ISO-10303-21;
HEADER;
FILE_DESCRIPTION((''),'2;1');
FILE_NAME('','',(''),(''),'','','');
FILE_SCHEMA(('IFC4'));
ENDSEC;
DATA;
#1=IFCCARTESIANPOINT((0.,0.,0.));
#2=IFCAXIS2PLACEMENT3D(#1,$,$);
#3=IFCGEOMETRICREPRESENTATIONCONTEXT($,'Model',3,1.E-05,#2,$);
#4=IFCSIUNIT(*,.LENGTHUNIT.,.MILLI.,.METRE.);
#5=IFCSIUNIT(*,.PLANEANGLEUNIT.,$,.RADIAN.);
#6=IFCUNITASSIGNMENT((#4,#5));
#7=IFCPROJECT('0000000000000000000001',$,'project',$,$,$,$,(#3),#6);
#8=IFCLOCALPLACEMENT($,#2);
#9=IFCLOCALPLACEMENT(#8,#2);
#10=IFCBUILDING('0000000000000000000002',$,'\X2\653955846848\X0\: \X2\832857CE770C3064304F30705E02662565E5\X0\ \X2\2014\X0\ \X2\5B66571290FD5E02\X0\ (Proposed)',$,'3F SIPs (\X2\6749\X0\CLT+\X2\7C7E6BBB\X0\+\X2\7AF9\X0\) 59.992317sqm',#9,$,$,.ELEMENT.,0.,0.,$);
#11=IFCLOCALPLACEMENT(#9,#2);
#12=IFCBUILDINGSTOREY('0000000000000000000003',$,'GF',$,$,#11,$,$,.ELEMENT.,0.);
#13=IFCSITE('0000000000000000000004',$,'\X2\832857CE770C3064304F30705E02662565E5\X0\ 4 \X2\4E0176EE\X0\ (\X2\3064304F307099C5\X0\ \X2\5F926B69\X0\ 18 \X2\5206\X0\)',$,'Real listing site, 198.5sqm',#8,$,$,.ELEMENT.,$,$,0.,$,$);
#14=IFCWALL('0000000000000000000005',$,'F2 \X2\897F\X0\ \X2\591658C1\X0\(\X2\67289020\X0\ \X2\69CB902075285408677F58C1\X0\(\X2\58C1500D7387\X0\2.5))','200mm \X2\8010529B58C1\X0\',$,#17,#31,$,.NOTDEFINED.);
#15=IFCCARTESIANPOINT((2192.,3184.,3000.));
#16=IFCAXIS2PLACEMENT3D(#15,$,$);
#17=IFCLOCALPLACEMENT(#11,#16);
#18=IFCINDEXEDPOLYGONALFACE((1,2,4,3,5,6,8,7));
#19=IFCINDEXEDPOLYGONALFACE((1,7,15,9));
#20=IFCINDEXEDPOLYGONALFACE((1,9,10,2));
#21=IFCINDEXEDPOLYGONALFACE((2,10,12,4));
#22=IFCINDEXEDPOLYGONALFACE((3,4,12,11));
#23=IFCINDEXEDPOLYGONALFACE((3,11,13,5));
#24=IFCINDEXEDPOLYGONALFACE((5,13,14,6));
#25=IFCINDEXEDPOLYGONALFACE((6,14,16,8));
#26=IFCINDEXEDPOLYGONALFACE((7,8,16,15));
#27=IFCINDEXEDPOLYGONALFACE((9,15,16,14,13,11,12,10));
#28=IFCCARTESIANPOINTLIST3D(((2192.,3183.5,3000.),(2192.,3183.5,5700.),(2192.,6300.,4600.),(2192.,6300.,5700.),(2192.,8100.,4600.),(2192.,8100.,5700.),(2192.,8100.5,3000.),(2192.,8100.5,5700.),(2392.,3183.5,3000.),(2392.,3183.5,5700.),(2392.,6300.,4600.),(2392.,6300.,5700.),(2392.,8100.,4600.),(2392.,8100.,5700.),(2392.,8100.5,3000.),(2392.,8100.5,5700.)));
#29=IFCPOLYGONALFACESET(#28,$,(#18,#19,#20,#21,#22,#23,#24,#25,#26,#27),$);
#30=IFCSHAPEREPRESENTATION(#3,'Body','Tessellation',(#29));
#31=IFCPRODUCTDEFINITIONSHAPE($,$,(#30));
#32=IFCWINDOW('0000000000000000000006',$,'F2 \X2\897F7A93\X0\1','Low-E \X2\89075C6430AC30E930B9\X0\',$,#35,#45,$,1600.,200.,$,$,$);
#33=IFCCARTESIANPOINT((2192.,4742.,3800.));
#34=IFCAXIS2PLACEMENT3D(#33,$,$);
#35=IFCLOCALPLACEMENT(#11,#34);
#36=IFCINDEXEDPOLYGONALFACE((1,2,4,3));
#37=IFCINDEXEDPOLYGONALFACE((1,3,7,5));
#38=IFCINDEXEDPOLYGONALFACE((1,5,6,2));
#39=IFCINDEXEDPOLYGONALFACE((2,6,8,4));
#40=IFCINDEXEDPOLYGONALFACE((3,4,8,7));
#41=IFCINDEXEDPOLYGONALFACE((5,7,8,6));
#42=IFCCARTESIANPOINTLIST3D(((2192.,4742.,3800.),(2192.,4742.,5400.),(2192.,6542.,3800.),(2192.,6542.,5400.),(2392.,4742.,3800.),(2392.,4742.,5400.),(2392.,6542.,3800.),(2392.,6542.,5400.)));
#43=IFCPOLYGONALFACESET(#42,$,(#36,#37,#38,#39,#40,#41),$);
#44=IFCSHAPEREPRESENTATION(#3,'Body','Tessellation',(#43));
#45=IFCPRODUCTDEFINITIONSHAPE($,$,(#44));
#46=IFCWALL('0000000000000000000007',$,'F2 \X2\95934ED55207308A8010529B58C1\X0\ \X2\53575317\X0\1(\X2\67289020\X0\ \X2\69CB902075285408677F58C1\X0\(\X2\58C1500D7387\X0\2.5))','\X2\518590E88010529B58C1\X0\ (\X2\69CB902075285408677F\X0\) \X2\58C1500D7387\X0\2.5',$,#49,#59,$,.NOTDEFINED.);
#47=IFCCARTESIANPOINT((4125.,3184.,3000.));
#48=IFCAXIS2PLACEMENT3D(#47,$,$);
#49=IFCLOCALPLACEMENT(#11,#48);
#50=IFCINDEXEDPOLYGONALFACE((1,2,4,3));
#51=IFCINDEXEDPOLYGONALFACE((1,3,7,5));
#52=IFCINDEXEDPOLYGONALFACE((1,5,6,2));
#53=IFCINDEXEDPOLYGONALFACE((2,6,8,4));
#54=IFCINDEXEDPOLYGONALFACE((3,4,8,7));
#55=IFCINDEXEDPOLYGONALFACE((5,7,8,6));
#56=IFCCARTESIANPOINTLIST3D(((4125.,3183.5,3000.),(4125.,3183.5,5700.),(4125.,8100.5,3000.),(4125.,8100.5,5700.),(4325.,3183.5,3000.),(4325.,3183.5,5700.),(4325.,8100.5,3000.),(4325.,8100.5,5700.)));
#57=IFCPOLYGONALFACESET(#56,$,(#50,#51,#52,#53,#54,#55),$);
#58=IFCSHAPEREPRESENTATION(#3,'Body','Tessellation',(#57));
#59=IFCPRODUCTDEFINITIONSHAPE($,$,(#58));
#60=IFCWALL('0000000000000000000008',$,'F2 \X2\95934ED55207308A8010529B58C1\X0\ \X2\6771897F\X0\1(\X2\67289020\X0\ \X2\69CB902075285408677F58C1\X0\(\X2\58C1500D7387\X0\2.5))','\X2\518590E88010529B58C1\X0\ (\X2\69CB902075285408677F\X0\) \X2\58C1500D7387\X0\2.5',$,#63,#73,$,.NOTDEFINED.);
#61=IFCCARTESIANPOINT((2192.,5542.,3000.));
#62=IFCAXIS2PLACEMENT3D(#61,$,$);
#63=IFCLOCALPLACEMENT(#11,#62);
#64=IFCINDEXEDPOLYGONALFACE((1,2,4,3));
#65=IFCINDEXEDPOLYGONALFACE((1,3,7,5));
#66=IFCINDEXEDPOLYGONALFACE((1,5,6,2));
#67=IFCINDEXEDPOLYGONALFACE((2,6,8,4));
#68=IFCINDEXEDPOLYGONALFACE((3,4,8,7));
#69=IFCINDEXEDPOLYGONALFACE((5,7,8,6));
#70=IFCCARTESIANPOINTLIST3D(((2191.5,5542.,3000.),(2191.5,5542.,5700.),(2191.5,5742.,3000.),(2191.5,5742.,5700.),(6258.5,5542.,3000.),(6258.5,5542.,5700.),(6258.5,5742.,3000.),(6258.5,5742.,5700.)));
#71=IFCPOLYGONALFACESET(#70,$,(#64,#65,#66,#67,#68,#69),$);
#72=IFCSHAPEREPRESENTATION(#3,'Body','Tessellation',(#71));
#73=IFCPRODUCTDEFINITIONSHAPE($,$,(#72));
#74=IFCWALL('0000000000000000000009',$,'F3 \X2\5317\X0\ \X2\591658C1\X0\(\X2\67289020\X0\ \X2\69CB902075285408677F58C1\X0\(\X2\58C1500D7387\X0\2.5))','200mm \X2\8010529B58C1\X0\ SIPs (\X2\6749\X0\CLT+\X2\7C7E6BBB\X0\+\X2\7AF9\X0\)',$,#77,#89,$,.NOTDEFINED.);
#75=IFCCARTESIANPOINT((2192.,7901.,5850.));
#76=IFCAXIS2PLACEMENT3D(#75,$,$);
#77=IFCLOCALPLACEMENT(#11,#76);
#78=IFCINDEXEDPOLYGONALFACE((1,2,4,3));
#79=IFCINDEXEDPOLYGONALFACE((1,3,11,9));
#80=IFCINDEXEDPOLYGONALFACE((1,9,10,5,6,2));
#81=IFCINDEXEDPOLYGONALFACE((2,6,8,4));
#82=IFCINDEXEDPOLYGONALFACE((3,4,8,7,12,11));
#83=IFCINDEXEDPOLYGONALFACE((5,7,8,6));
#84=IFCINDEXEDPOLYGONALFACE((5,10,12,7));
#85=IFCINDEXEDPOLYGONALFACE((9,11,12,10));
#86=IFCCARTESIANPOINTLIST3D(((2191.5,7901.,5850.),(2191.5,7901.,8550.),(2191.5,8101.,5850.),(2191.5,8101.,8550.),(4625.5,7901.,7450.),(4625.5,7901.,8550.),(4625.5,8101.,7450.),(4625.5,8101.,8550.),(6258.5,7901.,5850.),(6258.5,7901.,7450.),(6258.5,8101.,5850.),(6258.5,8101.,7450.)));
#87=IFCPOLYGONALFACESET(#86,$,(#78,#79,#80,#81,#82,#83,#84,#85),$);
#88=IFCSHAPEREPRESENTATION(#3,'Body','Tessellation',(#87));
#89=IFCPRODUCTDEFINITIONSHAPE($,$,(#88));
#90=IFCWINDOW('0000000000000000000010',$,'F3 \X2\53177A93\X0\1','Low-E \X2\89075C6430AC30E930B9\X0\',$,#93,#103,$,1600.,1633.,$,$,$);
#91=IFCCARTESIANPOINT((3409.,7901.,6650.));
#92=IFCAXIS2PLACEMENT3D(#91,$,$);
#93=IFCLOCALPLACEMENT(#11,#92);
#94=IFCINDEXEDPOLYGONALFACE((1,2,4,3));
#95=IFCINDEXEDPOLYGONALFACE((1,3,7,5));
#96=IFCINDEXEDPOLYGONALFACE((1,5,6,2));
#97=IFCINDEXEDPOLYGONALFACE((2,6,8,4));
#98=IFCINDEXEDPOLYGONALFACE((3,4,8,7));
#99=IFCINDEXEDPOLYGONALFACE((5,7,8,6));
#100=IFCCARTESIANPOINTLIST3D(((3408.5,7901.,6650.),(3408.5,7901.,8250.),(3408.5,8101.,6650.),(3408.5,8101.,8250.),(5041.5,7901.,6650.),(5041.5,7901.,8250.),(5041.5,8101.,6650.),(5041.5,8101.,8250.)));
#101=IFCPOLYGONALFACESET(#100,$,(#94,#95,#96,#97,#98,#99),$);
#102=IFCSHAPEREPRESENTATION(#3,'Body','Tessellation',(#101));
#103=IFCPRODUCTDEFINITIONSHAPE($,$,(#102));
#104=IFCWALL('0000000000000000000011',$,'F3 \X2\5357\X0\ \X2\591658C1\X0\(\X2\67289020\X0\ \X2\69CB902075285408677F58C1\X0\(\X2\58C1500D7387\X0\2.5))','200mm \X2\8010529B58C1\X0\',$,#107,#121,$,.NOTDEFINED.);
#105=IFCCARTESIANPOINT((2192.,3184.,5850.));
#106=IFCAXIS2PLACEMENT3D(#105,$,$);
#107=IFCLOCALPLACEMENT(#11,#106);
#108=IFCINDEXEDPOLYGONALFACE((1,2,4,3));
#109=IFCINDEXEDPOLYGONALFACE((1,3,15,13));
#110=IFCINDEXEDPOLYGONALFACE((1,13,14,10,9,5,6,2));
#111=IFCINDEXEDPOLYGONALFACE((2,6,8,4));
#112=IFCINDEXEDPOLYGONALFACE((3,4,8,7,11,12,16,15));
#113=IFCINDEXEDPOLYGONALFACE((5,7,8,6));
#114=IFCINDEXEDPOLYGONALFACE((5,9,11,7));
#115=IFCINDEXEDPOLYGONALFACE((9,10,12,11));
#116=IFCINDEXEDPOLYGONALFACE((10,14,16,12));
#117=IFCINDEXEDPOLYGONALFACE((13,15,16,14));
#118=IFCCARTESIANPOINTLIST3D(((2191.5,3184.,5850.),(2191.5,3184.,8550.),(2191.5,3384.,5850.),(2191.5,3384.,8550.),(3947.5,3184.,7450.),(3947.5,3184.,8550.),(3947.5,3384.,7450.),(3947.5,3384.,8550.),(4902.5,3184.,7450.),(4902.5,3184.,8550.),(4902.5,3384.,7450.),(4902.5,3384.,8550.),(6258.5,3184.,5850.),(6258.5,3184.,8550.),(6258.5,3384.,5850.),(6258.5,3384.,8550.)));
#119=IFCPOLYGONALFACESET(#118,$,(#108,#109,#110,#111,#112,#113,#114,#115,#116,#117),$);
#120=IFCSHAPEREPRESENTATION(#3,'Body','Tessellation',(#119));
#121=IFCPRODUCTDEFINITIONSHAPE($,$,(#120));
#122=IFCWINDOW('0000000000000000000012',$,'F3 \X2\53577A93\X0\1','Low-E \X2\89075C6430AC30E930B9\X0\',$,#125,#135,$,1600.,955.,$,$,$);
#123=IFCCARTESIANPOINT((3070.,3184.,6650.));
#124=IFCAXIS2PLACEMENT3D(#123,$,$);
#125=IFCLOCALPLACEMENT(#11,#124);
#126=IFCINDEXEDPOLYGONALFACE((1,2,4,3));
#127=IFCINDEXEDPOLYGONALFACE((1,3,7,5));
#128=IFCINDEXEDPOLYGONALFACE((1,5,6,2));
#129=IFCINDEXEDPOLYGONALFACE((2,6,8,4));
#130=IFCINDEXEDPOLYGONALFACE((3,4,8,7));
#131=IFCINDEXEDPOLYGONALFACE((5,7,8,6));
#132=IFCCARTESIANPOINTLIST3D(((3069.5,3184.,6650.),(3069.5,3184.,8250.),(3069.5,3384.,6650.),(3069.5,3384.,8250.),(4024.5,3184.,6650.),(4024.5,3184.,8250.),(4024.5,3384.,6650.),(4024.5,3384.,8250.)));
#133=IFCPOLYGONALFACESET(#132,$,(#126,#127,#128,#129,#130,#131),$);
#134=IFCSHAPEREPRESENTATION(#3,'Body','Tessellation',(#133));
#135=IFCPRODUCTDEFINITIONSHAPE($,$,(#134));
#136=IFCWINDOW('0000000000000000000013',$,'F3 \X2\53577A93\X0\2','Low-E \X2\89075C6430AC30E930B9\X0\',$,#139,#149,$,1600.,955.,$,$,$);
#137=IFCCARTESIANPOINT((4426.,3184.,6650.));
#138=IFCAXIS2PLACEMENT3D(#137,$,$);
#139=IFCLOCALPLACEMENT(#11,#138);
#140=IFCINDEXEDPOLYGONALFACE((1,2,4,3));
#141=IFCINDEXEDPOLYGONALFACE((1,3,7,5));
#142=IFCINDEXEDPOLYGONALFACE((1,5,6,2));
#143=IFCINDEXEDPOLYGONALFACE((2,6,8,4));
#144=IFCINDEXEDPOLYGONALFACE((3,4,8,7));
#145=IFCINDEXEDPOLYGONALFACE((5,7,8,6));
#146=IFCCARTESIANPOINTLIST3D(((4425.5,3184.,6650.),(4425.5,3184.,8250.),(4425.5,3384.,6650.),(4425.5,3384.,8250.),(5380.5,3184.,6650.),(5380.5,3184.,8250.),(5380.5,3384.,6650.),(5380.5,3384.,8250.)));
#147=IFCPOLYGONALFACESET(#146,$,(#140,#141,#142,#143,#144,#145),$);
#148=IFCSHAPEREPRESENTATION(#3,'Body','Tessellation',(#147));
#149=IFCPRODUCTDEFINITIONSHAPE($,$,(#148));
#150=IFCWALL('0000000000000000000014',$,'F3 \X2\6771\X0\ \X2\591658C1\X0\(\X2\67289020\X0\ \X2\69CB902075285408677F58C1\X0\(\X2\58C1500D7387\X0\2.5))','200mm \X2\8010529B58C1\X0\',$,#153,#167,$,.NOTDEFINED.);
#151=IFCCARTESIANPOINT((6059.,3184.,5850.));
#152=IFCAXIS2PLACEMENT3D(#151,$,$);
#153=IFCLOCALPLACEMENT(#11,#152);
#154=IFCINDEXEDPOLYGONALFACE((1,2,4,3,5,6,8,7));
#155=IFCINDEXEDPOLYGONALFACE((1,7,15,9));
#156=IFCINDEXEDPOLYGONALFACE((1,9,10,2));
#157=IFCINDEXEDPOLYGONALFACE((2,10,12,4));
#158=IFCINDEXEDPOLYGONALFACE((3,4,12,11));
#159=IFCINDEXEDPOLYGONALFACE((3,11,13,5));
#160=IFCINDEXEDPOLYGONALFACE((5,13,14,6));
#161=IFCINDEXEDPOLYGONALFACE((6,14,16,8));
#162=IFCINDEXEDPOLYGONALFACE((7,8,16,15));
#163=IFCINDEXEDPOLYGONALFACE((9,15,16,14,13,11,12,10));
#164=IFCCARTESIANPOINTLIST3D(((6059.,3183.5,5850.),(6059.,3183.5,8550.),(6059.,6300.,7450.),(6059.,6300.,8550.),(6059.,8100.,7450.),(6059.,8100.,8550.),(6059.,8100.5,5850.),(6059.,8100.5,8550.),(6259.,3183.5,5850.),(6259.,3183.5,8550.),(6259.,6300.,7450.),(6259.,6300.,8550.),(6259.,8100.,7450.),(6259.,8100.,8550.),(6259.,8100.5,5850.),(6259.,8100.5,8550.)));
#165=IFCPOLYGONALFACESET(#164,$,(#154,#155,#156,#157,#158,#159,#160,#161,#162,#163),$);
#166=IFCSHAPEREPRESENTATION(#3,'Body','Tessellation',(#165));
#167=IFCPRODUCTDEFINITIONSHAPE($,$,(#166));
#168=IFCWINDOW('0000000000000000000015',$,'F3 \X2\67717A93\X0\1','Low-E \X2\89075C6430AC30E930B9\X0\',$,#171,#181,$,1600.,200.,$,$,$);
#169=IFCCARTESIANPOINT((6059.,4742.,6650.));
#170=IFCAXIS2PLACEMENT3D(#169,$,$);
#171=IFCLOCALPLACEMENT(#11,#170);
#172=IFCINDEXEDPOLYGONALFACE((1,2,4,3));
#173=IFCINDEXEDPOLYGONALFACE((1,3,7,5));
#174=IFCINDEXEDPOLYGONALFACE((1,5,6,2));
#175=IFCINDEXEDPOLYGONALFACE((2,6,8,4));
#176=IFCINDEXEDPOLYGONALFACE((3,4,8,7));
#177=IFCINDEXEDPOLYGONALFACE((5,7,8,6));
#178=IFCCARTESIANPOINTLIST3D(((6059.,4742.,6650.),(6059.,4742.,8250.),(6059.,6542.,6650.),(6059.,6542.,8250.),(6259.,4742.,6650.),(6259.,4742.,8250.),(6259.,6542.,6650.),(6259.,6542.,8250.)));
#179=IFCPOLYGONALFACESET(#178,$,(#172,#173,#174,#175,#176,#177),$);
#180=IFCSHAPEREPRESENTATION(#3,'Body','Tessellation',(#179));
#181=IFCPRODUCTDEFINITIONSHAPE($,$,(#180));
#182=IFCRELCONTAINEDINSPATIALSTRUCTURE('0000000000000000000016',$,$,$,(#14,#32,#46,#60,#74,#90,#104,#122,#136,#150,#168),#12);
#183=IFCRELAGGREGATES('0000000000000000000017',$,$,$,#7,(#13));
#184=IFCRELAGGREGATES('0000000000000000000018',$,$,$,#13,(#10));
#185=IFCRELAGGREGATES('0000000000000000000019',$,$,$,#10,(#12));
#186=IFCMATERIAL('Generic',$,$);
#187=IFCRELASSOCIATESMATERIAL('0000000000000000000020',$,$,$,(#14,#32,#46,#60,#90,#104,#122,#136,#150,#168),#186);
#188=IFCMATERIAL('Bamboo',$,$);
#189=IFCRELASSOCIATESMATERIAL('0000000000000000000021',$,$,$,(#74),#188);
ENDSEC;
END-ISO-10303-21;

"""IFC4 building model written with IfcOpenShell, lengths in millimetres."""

from ifc_helpers import new_model, si_unit, frame, frame_2d, origin, place, context, project, spatial, rectangle, extrude, material, element, fill, save


model = new_model("IFC4")

# Units and contexts
model_context = context("Model", 3, precision=1e-05, world=origin())
ifc_project = project(units=[si_unit("LENGTHUNIT", "METRE", prefix="MILLI"), si_unit("PLANEANGLEUNIT", "RADIAN")], contexts=[model_context])

# Site, building, storey
site_placement = place(None, origin())
site = spatial("IfcSite", under=ifc_project, at=site_placement, Name="茨城県つくば市春日 4 丁目 (つくば駅 徒歩 18 分)", ObjectType="Real listing site, 198.5sqm", CompositionType="ELEMENT", RefElevation=0.0)
building_placement = place(site_placement, origin())
building = spatial("IfcBuilding", under=site, at=building_placement, Name="改善案: 茨城県つくば市春日 — 学園都市 (Proposed)", ObjectType="3F SIPs (杉CLT+籾殻+竹) 59.992317sqm", CompositionType="ELEMENT", ElevationOfRefHeight=0.0, ElevationOfTerrain=0.0)
storey_placement = place(building_placement, origin())
storey = spatial("IfcBuildingStorey", under=building, at=storey_placement, Name="GF", CompositionType="ELEMENT", Elevation=0.0)

# Shared definitions
ifc_material_1 = material(Name="Generic")

# Wall, opening, window
wall_1_placement = place(storey_placement, frame((2192.0, 3184.0, 3000.0)))
wall_1 = element("IfcWall", 1, at=wall_1_placement, inside=storey, material=ifc_material_1, Name="F2 西 外壁(木造 構造用合板壁(壁倍率2.5))", Description="200mm 耐力壁", PredefinedType="NOTDEFINED", context=model_context, shape_type="SweptSolid", body=[
    extrude(rectangle(XDim=200.0, YDim=4917.0, at=frame_2d((100.0, 2458.0))), frame((2192.0, 3184.0, 3000.0)), (0.0, 0.0, 1.0), 2700.0),
])
opening_1_placement = place(storey_placement, frame((2192.0, 4742.0, 3800.0)))
opening_1 = element("IfcOpeningElement", 2, at=opening_1_placement, cuts=wall_1, PredefinedType="NOTDEFINED", context=model_context, shape_type="SweptSolid", body=[
    extrude(rectangle(XDim=200.0, YDim=1800.0, at=frame_2d((100.0, 900.0))), frame((2192.0, 4742.0, 3800.0)), (0.0, 0.0, 1.0), 1600.0),
])
window_1_placement = place(storey_placement, frame((2192.0, 4742.0, 3800.0)))
window_1 = element("IfcWindow", 3, at=window_1_placement, inside=storey, material=ifc_material_1, Name="F2 西窓1", Description="Low-E 複層ガラス", OverallHeight=1600.0, OverallWidth=200.0, context=model_context, shape_type="SweptSolid", body=[
    extrude(rectangle(XDim=200.0, YDim=1800.0, at=frame_2d((100.0, 900.0))), frame((2192.0, 4742.0, 3800.0)), (0.0, 0.0, 1.0), 1600.0),
])
fill(opening_1, window_1)

# Walls
wall_2_placement = place(storey_placement, frame((4125.0, 3184.0, 3000.0)))
element("IfcWall", 4, at=wall_2_placement, inside=storey, material=ifc_material_1, Name="F2 間仕切り耐力壁 南北1(木造 構造用合板壁(壁倍率2.5))", Description="内部耐力壁 (構造用合板) 壁倍率2.5", PredefinedType="NOTDEFINED", context=model_context, shape_type="SweptSolid", body=[
    extrude(rectangle(XDim=200.0, YDim=4917.0, at=frame_2d((100.0, 2458.0))), frame((4125.0, 3184.0, 3000.0)), (0.0, 0.0, 1.0), 2700.0),
])
wall_3_placement = place(storey_placement, frame((2192.0, 5542.0, 3000.0)))
element("IfcWall", 5, at=wall_3_placement, inside=storey, material=ifc_material_1, Name="F2 間仕切り耐力壁 東西1(木造 構造用合板壁(壁倍率2.5))", Description="内部耐力壁 (構造用合板) 壁倍率2.5", PredefinedType="NOTDEFINED", context=model_context, shape_type="SweptSolid", body=[
    extrude(rectangle(XDim=4067.0, YDim=200.0, at=frame_2d((2033.0, 100.0))), frame((2192.0, 5542.0, 3000.0)), (0.0, 0.0, 1.0), 2700.0),
])

# Wall, opening, window
ifc_material_2 = material(Name="Bamboo")
wall_4_placement = place(storey_placement, frame((2192.0, 7901.0, 5850.0)))
wall_4 = element("IfcWall", 6, at=wall_4_placement, inside=storey, material=ifc_material_2, Name="F3 北 外壁(木造 構造用合板壁(壁倍率2.5))", Description="200mm 耐力壁 SIPs (杉CLT+籾殻+竹)", PredefinedType="NOTDEFINED", context=model_context, shape_type="SweptSolid", body=[
    extrude(rectangle(XDim=4067.0, YDim=200.0, at=frame_2d((2033.0, 100.0))), frame((2192.0, 7901.0, 5850.0)), (0.0, 0.0, 1.0), 2700.0),
])
opening_2_placement = place(storey_placement, frame((3409.0, 7901.0, 6650.0)))
opening_2 = element("IfcOpeningElement", 7, at=opening_2_placement, cuts=wall_4, PredefinedType="NOTDEFINED", context=model_context, shape_type="SweptSolid", body=[
    extrude(rectangle(XDim=1633.0, YDim=200.0, at=frame_2d((816.0, 100.0))), frame((3409.0, 7901.0, 6650.0)), (0.0, 0.0, 1.0), 1600.0),
])
window_2_placement = place(storey_placement, frame((3409.0, 7901.0, 6650.0)))
window_2 = element("IfcWindow", 8, at=window_2_placement, inside=storey, material=ifc_material_1, Name="F3 北窓1", Description="Low-E 複層ガラス", OverallHeight=1600.0, OverallWidth=1633.0, context=model_context, shape_type="SweptSolid", body=[
    extrude(rectangle(XDim=1633.0, YDim=200.0, at=frame_2d((816.0, 100.0))), frame((3409.0, 7901.0, 6650.0)), (0.0, 0.0, 1.0), 1600.0),
])
fill(opening_2, window_2)

# Wall, openings, windows
wall_5_placement = place(storey_placement, frame((2192.0, 3184.0, 5850.0)))
wall_5 = element("IfcWall", 9, at=wall_5_placement, inside=storey, material=ifc_material_1, Name="F3 南 外壁(木造 構造用合板壁(壁倍率2.5))", Description="200mm 耐力壁", PredefinedType="NOTDEFINED", context=model_context, shape_type="SweptSolid", body=[
    extrude(rectangle(XDim=4067.0, YDim=200.0, at=frame_2d((2033.0, 100.0))), frame((2192.0, 3184.0, 5850.0)), (0.0, 0.0, 1.0), 2700.0),
])
opening_3_placement = place(storey_placement, frame((3070.0, 3184.0, 6650.0)))
opening_3 = element("IfcOpeningElement", 10, at=opening_3_placement, cuts=wall_5, PredefinedType="NOTDEFINED", context=model_context, shape_type="SweptSolid", body=[
    extrude(rectangle(XDim=955.0, YDim=200.0, at=frame_2d((477.0, 100.0))), frame((3070.0, 3184.0, 6650.0)), (0.0, 0.0, 1.0), 1600.0),
])
opening_4_placement = place(storey_placement, frame((4426.0, 3184.0, 6650.0)))
opening_4 = element("IfcOpeningElement", 11, at=opening_4_placement, cuts=wall_5, PredefinedType="NOTDEFINED", context=model_context, shape_type="SweptSolid", body=[
    extrude(rectangle(XDim=955.0, YDim=200.0, at=frame_2d((477.0, 100.0))), frame((4426.0, 3184.0, 6650.0)), (0.0, 0.0, 1.0), 1600.0),
])
window_3_placement = place(storey_placement, frame((3070.0, 3184.0, 6650.0)))
window_3 = element("IfcWindow", 12, at=window_3_placement, inside=storey, material=ifc_material_1, Name="F3 南窓1", Description="Low-E 複層ガラス", OverallHeight=1600.0, OverallWidth=955.0, context=model_context, shape_type="SweptSolid", body=[
    extrude(rectangle(XDim=955.0, YDim=200.0, at=frame_2d((477.0, 100.0))), frame((3070.0, 3184.0, 6650.0)), (0.0, 0.0, 1.0), 1600.0),
])
fill(opening_3, window_3)
window_4_placement = place(storey_placement, frame((4426.0, 3184.0, 6650.0)))
window_4 = element("IfcWindow", 13, at=window_4_placement, inside=storey, material=ifc_material_1, Name="F3 南窓2", Description="Low-E 複層ガラス", OverallHeight=1600.0, OverallWidth=955.0, context=model_context, shape_type="SweptSolid", body=[
    extrude(rectangle(XDim=955.0, YDim=200.0, at=frame_2d((477.0, 100.0))), frame((4426.0, 3184.0, 6650.0)), (0.0, 0.0, 1.0), 1600.0),
])
fill(opening_4, window_4)

# Wall, opening, window
wall_6_placement = place(storey_placement, frame((6059.0, 3184.0, 5850.0)))
wall_6 = element("IfcWall", 14, at=wall_6_placement, inside=storey, material=ifc_material_1, Name="F3 東 外壁(木造 構造用合板壁(壁倍率2.5))", Description="200mm 耐力壁", PredefinedType="NOTDEFINED", context=model_context, shape_type="SweptSolid", body=[
    extrude(rectangle(XDim=200.0, YDim=4917.0, at=frame_2d((100.0, 2458.0))), frame((6059.0, 3184.0, 5850.0)), (0.0, 0.0, 1.0), 2700.0),
])
opening_5_placement = place(storey_placement, frame((6059.0, 4742.0, 6650.0)))
opening_5 = element("IfcOpeningElement", 15, at=opening_5_placement, cuts=wall_6, PredefinedType="NOTDEFINED", context=model_context, shape_type="SweptSolid", body=[
    extrude(rectangle(XDim=200.0, YDim=1800.0, at=frame_2d((100.0, 900.0))), frame((6059.0, 4742.0, 6650.0)), (0.0, 0.0, 1.0), 1600.0),
])
window_5_placement = place(storey_placement, frame((6059.0, 4742.0, 6650.0)))
window_5 = element("IfcWindow", 16, at=window_5_placement, inside=storey, material=ifc_material_1, Name="F3 東窓1", Description="Low-E 複層ガラス", OverallHeight=1600.0, OverallWidth=200.0, context=model_context, shape_type="SweptSolid", body=[
    extrude(rectangle(XDim=200.0, YDim=1800.0, at=frame_2d((100.0, 900.0))), frame((6059.0, 4742.0, 6650.0)), (0.0, 0.0, 1.0), 1600.0),
])
fill(opening_5, window_5)

save(model, "model.ifc")
